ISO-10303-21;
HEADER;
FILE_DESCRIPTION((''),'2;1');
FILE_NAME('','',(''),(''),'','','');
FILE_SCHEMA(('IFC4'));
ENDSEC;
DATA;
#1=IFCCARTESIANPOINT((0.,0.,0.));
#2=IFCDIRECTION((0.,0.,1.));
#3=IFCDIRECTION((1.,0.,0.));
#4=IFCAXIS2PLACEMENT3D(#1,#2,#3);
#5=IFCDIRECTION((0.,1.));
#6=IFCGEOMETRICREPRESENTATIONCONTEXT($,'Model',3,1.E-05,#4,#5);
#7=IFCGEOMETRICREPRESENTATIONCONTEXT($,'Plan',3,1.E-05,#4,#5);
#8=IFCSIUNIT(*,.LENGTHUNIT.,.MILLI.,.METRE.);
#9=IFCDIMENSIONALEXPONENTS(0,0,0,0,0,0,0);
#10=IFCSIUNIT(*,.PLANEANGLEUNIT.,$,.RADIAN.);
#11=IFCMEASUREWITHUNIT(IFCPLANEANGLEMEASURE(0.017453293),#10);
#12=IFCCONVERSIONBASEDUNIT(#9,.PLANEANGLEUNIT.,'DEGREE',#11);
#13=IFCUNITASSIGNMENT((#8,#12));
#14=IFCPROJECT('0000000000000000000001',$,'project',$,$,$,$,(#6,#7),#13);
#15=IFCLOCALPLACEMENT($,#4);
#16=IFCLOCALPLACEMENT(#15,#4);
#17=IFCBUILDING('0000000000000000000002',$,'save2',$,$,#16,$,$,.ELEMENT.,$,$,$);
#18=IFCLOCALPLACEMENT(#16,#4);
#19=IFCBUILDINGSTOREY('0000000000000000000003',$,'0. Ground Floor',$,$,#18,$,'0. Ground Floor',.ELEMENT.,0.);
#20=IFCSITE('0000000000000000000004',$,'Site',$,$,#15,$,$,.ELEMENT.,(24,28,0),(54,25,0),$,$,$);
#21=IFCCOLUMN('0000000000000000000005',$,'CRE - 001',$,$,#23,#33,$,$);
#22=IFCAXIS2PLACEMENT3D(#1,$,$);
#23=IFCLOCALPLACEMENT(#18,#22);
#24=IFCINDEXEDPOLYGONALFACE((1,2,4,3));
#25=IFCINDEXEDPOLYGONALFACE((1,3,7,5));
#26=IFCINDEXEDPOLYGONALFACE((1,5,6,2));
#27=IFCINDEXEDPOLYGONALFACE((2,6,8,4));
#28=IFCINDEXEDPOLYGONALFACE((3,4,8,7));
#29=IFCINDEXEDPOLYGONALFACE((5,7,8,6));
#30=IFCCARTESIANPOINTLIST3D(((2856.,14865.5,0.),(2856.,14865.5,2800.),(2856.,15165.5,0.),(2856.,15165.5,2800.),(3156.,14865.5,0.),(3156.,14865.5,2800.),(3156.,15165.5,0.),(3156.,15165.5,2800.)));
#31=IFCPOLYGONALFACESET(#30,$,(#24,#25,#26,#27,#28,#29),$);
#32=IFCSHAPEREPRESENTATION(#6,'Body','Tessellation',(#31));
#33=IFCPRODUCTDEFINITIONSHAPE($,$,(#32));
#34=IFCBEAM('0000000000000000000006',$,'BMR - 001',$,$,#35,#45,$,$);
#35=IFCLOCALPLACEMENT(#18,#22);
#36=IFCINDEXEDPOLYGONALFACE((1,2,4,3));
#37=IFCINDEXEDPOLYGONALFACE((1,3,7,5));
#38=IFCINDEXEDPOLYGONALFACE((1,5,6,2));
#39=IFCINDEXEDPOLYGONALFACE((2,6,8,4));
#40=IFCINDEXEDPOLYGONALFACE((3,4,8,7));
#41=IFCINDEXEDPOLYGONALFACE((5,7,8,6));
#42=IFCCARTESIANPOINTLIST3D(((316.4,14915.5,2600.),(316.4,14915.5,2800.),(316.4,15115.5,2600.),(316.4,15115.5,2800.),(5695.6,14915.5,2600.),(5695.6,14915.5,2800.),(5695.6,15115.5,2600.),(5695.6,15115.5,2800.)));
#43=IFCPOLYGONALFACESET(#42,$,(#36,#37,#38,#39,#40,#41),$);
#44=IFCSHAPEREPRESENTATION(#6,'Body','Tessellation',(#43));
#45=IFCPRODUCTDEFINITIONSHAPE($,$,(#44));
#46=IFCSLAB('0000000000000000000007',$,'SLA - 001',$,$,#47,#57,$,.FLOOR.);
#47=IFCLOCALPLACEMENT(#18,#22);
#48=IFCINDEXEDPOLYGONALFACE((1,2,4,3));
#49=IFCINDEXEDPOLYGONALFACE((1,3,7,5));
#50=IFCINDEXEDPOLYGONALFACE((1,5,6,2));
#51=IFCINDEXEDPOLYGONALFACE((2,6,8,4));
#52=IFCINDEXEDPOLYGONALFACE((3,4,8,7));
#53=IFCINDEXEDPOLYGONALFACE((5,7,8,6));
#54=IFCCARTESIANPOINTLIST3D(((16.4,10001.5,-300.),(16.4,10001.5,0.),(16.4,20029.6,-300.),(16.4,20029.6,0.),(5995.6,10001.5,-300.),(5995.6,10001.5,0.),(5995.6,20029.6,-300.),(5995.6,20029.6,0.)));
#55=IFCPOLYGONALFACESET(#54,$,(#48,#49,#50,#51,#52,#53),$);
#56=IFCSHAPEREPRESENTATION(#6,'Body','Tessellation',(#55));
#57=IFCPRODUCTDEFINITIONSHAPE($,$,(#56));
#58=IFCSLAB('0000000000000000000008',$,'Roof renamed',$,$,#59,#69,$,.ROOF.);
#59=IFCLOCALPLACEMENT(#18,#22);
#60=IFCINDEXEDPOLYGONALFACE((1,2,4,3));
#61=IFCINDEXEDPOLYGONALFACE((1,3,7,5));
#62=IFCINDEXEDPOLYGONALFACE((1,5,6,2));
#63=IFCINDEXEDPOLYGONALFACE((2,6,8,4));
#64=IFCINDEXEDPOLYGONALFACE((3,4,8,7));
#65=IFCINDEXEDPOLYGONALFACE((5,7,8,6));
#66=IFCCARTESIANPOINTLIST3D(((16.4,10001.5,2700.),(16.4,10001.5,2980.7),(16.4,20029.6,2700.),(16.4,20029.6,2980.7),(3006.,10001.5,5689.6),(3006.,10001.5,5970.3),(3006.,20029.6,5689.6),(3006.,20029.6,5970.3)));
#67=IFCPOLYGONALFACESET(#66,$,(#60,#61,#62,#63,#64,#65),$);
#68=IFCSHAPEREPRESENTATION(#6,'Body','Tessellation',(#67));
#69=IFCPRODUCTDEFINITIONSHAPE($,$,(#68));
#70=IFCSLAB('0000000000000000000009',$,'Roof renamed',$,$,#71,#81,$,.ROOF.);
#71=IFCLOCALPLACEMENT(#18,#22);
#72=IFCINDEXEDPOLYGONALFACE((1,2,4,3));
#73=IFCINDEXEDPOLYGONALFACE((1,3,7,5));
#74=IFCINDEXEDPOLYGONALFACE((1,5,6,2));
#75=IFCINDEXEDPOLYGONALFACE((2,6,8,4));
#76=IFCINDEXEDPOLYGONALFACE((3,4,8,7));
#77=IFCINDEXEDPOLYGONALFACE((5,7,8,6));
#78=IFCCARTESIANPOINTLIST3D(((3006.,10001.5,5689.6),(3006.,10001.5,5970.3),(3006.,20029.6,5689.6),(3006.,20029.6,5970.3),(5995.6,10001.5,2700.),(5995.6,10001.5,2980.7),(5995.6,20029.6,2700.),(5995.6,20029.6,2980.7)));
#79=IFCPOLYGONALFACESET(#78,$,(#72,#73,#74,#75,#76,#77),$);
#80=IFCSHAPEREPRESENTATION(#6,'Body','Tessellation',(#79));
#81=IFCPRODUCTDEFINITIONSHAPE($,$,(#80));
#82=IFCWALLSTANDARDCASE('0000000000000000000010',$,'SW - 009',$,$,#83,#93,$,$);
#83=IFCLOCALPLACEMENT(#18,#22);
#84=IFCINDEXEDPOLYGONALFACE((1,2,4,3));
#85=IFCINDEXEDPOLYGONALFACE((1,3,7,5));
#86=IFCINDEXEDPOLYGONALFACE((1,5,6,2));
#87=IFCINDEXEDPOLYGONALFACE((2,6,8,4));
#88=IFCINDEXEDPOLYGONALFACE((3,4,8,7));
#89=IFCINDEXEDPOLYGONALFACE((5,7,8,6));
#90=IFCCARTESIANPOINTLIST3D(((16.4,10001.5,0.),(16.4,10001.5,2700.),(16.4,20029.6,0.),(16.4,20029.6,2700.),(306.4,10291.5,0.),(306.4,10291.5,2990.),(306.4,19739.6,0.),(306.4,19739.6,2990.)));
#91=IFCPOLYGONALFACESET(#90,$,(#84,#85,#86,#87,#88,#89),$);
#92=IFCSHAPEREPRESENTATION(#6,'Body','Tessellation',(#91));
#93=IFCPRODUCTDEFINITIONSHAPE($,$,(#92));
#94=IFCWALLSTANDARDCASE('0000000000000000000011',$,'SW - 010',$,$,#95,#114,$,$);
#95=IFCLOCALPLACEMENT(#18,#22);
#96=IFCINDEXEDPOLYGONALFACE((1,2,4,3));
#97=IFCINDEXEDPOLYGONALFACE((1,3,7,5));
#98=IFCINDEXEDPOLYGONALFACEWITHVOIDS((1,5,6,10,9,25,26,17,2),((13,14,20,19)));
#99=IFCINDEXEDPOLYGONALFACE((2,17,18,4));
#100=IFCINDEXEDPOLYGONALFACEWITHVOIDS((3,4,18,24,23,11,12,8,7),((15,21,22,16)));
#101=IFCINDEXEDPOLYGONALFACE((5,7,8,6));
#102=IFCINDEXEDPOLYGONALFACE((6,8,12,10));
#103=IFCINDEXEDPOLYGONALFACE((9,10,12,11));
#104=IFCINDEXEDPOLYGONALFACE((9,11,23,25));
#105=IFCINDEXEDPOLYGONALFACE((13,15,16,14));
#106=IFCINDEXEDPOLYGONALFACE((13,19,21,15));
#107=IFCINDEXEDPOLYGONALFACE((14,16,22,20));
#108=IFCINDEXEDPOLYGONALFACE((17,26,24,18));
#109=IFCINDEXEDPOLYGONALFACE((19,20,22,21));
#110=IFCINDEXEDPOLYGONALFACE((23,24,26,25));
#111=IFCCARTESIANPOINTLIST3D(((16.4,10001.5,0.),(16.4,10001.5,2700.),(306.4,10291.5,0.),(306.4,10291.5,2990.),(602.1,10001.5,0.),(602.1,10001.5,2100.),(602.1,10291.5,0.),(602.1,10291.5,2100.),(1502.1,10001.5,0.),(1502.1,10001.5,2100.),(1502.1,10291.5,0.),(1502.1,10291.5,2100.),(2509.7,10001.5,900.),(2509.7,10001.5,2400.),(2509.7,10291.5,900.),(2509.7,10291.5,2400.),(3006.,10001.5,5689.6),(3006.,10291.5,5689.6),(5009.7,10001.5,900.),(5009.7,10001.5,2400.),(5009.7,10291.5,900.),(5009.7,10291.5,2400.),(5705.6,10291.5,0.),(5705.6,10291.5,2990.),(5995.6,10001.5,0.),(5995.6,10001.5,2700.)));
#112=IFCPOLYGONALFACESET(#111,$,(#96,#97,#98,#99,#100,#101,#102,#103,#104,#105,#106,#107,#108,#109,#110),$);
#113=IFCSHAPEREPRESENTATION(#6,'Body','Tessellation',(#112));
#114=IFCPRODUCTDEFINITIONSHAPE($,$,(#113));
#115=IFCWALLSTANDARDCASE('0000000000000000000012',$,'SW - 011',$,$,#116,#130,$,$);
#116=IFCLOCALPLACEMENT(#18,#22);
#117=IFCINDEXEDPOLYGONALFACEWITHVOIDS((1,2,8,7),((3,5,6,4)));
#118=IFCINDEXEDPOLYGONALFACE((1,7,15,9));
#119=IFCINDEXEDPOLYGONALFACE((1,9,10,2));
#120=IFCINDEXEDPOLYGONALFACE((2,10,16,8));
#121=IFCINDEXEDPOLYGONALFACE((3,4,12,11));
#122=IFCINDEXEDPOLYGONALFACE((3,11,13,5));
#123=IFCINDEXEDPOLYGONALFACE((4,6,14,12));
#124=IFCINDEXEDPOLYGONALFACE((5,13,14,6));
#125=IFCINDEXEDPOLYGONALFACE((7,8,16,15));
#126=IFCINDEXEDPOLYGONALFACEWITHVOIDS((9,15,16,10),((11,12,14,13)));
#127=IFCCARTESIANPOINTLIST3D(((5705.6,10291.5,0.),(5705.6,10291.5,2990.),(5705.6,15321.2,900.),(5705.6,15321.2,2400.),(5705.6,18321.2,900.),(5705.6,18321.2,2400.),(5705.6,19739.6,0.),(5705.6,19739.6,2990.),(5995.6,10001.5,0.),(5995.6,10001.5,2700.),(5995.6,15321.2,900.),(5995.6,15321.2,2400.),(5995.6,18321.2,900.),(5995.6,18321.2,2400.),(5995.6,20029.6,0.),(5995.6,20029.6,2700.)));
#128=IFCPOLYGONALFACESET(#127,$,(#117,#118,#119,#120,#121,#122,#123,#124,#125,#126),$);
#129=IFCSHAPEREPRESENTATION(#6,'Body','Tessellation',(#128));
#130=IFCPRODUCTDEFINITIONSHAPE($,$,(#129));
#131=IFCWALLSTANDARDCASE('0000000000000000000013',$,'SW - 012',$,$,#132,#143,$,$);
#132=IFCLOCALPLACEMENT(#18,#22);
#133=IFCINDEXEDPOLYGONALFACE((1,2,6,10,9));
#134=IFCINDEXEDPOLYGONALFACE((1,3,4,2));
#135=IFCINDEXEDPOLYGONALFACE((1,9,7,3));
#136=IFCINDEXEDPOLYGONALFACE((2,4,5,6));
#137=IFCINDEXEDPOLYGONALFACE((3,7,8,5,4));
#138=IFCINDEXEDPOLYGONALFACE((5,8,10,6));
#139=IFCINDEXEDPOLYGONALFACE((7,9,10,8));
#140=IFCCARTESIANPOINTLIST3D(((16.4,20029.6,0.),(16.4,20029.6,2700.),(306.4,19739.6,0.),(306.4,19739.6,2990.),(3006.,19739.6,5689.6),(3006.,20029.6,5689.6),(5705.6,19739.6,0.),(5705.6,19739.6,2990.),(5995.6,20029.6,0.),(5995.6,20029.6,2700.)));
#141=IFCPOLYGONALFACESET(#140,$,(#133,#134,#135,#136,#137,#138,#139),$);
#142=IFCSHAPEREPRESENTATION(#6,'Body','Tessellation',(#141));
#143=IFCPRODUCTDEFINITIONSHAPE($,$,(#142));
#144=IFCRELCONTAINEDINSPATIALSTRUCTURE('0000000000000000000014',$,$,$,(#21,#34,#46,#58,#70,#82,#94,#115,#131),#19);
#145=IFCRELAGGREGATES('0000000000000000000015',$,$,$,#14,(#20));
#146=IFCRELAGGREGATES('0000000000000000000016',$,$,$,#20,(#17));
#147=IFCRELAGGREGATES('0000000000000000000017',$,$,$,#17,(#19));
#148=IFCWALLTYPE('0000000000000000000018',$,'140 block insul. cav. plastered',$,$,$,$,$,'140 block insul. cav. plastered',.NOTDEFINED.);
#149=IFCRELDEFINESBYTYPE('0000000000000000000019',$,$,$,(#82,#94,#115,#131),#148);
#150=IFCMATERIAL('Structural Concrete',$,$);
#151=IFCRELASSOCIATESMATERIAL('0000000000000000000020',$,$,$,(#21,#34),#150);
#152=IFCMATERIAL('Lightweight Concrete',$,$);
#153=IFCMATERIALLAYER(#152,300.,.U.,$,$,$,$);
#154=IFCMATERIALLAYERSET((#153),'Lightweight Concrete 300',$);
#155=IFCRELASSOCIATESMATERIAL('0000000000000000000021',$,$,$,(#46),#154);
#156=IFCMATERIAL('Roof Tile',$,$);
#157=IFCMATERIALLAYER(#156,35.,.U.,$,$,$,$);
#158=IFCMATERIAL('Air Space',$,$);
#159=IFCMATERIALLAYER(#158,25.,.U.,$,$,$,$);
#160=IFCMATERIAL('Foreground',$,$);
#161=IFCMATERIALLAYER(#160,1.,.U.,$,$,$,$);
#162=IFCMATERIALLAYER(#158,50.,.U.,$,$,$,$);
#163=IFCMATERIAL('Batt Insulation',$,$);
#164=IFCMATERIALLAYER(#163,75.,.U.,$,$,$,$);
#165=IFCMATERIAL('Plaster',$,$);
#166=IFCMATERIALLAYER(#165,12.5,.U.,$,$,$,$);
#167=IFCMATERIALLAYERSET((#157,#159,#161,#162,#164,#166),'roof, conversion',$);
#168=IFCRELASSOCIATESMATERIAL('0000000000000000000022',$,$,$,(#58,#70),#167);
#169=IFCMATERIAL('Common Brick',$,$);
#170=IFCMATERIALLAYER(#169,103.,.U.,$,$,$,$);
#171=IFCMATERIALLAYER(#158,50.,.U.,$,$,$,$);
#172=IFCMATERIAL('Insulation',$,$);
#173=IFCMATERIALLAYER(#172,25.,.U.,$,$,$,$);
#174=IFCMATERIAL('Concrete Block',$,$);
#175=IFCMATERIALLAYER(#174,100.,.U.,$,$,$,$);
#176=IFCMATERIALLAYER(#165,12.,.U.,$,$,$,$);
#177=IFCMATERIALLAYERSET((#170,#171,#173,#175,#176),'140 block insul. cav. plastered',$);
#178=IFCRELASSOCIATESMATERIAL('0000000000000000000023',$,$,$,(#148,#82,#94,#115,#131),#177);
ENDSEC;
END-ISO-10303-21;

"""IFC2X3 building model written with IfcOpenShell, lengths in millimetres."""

from ifc_helpers import new_model, entity, si_unit, converted_unit, direction, frame, frame_2d, origin_with_axes, origin_2d_with_axis, place, context, project, spatial, polyline, rectangle, outline, extrude, clip, halfspace, bounded_halfspace, material, layer, layer_set, layer_usage, type_object, element, save


model = new_model("IFC2X3")

# Units and contexts
model_context = context("Model", 3, precision=1e-05, world=origin_with_axes(), true_north=direction((0.0, 1.0)))
plan_context = context("Plan", 3, precision=1e-05, world=origin_with_axes(), true_north=direction((0.0, 1.0)))
ifc_project = project(units=[si_unit("LENGTHUNIT", "METRE", prefix="MILLI"), converted_unit("PLANEANGLEUNIT", "DEGREE", entity("IfcPlaneAngleMeasure", 0.017453293), si_unit("PLANEANGLEUNIT", "RADIAN"), dimensions=[0, 0, 0, 0, 0, 0, 0])], contexts=[model_context, plan_context])

# Site, building, storey
site_placement = place(None, origin_with_axes())
site = spatial("IfcSite", under=ifc_project, at=site_placement, Name="Site", CompositionType="ELEMENT", RefLatitude=(24, 28, 0), RefLongitude=(54, 25, 0))
building_placement = place(site_placement, origin_with_axes())
building = spatial("IfcBuilding", under=site, at=building_placement, Name="save2", CompositionType="ELEMENT")
storey_placement = place(building_placement, origin_with_axes())
storey = spatial("IfcBuildingStorey", under=building, at=storey_placement, Name="0. Ground Floor", LongName="0. Ground Floor", CompositionType="ELEMENT", Elevation=0.0)

# Column
ifc_material_1 = material(Name="Structural Concrete")
column_placement = place(storey_placement, frame((3006.0, 15015.5, 0.0), z_axis=(0.0, 0.0, 1.0), x_axis=(1.0, 0.0, 0.0)))
element("IfcColumn", 1, at=column_placement, inside=storey, material=ifc_material_1, Name="CRE - 001", context=model_context, shape_type="SweptSolid", body=[
    extrude(rectangle(XDim=300.0, YDim=300.0, at=origin_2d_with_axis()), origin_with_axes(), (0.0, 0.0, 1.0), 2800.0),
])

# Beam
beam_placement = place(storey_placement, frame((316.4, 15015.5, 2800.0), z_axis=(0.0, 0.0, 1.0), x_axis=(0.0, -1.0, 0.0)))
element("IfcBeam", 2, at=beam_placement, inside=storey, material=ifc_material_1, Name="BMR - 001", context=model_context, shape_type="SweptSolid", body=[
    extrude(rectangle(XDim=200.0, YDim=200.0, at=frame_2d((-100.0, 0.0), x_axis=(1.0, 0.0))), frame((0.0, 0.0, 0.0), z_axis=(0.0, 1.0, 0.0), x_axis=(0.0, 0.0, 1.0)), (0.0, 0.0, 1.0), 5379.1),
])

# Slabs
ifc_material_2 = material(Name="Lightweight Concrete")
ifc_layer_1 = layer(ifc_material_2, 300.0, ventilated="UNKNOWN")
ifc_layer_set_1 = layer_set([ifc_layer_1], Name="Lightweight Concrete 300")
ifc_layer_usage_1 = layer_usage(ifc_layer_set_1, "AXIS3", "NEGATIVE", 300.0)
slab_1_placement = place(storey_placement, frame((16.4, 20029.6, -300.0), z_axis=(0.0, 0.0, 1.0), x_axis=(1.0, 0.0, 0.0)))
element("IfcSlab", 3, at=slab_1_placement, inside=storey, material=ifc_layer_usage_1, Name="SLA - 001", PredefinedType="FLOOR", context=model_context, shape_type="SweptSolid", body=[
    extrude(outline(polyline([(0.0, 0.0), (5979.1, 0.0), (5979.1, -10028.0), (0.0, -10028.0), (0.0, 0.0)])), origin_with_axes(), (0.0, 0.0, 1.0), 300.0),
])
ifc_material_3 = material(Name="Roof Tile")
ifc_layer_2 = layer(ifc_material_3, 35.0, ventilated="UNKNOWN")
ifc_material_4 = material(Name="Air Space")
ifc_layer_3 = layer(ifc_material_4, 25.0, ventilated="UNKNOWN")
ifc_material_5 = material(Name="Foreground")
ifc_layer_4 = layer(ifc_material_5, 1.0, ventilated="UNKNOWN")
ifc_layer_5 = layer(ifc_material_4, 50.0, ventilated="UNKNOWN")
ifc_material_6 = material(Name="Batt Insulation")
ifc_layer_6 = layer(ifc_material_6, 75.0, ventilated="UNKNOWN")
ifc_material_7 = material(Name="Plaster")
ifc_layer_7 = layer(ifc_material_7, 12.5, ventilated="UNKNOWN")
ifc_layer_set_2 = layer_set([ifc_layer_2, ifc_layer_3, ifc_layer_4, ifc_layer_5, ifc_layer_6, ifc_layer_7], Name="roof, conversion")
ifc_layer_usage_2 = layer_usage(ifc_layer_set_2, "AXIS3", "NEGATIVE", 198.5)
slab_2_placement = place(storey_placement, frame((16.4, 20029.6, 2700.0), z_axis=(-0.707107, 0.0, 0.707107), x_axis=(0.0, -1.0, 0.0)))
element("IfcSlab", 4, at=slab_2_placement, inside=storey, material=ifc_layer_usage_2, Name="Roof renamed", PredefinedType="ROOF", context=model_context, shape_type="SweptSolid", body=[
    extrude(outline(polyline([(0.0, 0.0), (0.0, 4227.9), (10028.0, 4227.9), (10028.0, 0.0), (0.0, 0.0)])), origin_with_axes(), (0.0, 0.707107, 0.707107), 280.7),
])
ifc_layer_usage_3 = layer_usage(ifc_layer_set_2, "AXIS3", "NEGATIVE", 198.5)
slab_3_placement = place(storey_placement, frame((5995.6, 10001.5, 2700.0), z_axis=(0.707107, 0.0, 0.707107), x_axis=(0.0, 1.0, 0.0)))
element("IfcSlab", 5, at=slab_3_placement, inside=storey, material=ifc_layer_usage_3, Name="Roof renamed", PredefinedType="ROOF", context=model_context, shape_type="SweptSolid", body=[
    extrude(outline(polyline([(0.0, 0.0), (10028.0, 0.0), (10028.0, 4227.9), (0.0, 4227.9), (0.0, 0.0)])), origin_with_axes(), (0.0, 0.707107, 0.707107), 280.7),
])

# Wall
ifc_material_8 = material(Name="Common Brick")
ifc_layer_8 = layer(ifc_material_8, 103.0, ventilated="UNKNOWN")
ifc_layer_9 = layer(ifc_material_4, 50.0, ventilated="UNKNOWN")
ifc_material_9 = material(Name="Insulation")
ifc_layer_10 = layer(ifc_material_9, 25.0, ventilated="UNKNOWN")
ifc_material_10 = material(Name="Concrete Block")
ifc_layer_11 = layer(ifc_material_10, 100.0, ventilated="UNKNOWN")
ifc_layer_12 = layer(ifc_material_7, 12.0, ventilated="UNKNOWN")
ifc_layer_set_3 = layer_set([ifc_layer_8, ifc_layer_9, ifc_layer_10, ifc_layer_11, ifc_layer_12], Name="140 block insul. cav. plastered")
ifc_layer_usage_4 = layer_usage(ifc_layer_set_3, "AXIS2", "POSITIVE", 0.0)
wall_type_1 = type_object("IfcWallType", Name="140 block insul. cav. plastered", ElementType="140 block insul. cav. plastered", PredefinedType="NOTDEFINED", material=ifc_layer_set_3)
wall_1_placement = place(storey_placement, frame((16.4, 20029.6, 0.0), z_axis=(0.0, 0.0, 1.0), x_axis=(0.0, -1.0, 0.0)))
element("IfcWallStandardCase", 6, at=wall_1_placement, inside=storey, type_object=wall_type_1, material=ifc_layer_usage_4, Name="SW - 009", context=model_context, shape_type="Clipping", body=[
    clip(extrude(outline(polyline([(0.0, 0.0), (10028.0, 0.0), (9738.0, 290.0), (290.0, 290.0), (0.0, 0.0)])), origin_with_axes(), (0.0, 0.0, 1.0), 6000.0), halfspace(frame((0.0, -1350.0, 1350.0), z_axis=(0.0, 0.707107, -0.707107), x_axis=(0.0, 0.707107, 0.707107)), True)),
])

# Wall, openings
ifc_layer_usage_5 = layer_usage(ifc_layer_set_3, "AXIS2", "POSITIVE", 0.0)
wall_2_placement = place(storey_placement, frame((16.4, 10001.5, 0.0), z_axis=(0.0, 0.0, 1.0), x_axis=(1.0, 0.0, 0.0)))
wall_2 = element("IfcWallStandardCase", 7, at=wall_2_placement, inside=storey, type_object=wall_type_1, material=ifc_layer_usage_5, Name="SW - 010", context=model_context, shape_type="Clipping", body=[
    clip(clip(extrude(outline(polyline([(0.0, 0.0), (5979.1, 0.0), (5689.1, 290.0), (290.0, 290.0), (0.0, 0.0)])), origin_with_axes(), (0.0, 0.0, 1.0), 6000.0), bounded_halfspace(frame((-1350.0, 0.0, 1350.0), z_axis=(0.707107, 0.0, -0.707107), x_axis=(0.0, 1.0, 0.0)), True, origin_with_axes(), polyline([(2989.6, -145.0), (2989.6, 435.0), (-10.0, 435.0), (-10.0, -145.0), (2989.6, -145.0)]))), bounded_halfspace(frame((4339.6, 0.0, 4339.6), z_axis=(-0.707107, 0.0, -0.707107), x_axis=(0.0, 1.0, 0.0)), True, origin_with_axes(), polyline([(2989.6, -145.0), (2989.6, 435.0), (5989.1, 435.0), (5989.1, -145.0), (2989.6, -145.0)]))),
])
opening_1_placement = place(wall_2_placement, frame((1035.6, 0.0, 0.0), z_axis=(0.0, 0.0, 1.0), x_axis=(1.0, 0.0, 0.0)))
element("IfcOpeningElement", 8, at=opening_1_placement, cuts=wall_2, ObjectType="Opening", context=model_context, shape_type="SweptSolid", body=[
    extrude(rectangle(XDim=900.0, YDim=2100.0, at=frame_2d((0.0, 1050.0), x_axis=(-1.0, 0.0))), frame((0.0, 0.0, 0.0), z_axis=(0.0, 1.0, 0.0), x_axis=(-1.0, 0.0, 0.0)), (0.0, 0.0, 1.0), 290.0),
])
opening_2_placement = place(wall_2_placement, frame((3743.3, 0.0, 900.0), z_axis=(0.0, 0.0, 1.0), x_axis=(1.0, 0.0, 0.0)))
element("IfcOpeningElement", 9, at=opening_2_placement, cuts=wall_2, ObjectType="Opening", context=model_context, shape_type="SweptSolid", body=[
    extrude(rectangle(XDim=2500.0, YDim=1500.0, at=frame_2d((0.0, 750.0), x_axis=(-1.0, 0.0))), frame((0.0, 0.0, 0.0), z_axis=(0.0, 1.0, 0.0), x_axis=(-1.0, 0.0, 0.0)), (0.0, 0.0, 1.0), 290.0),
])

# Wall, opening
ifc_layer_usage_6 = layer_usage(ifc_layer_set_3, "AXIS2", "POSITIVE", 0.0)
wall_3_placement = place(storey_placement, frame((5995.6, 10001.5, 0.0), z_axis=(0.0, 0.0, 1.0), x_axis=(0.0, 1.0, 0.0)))
wall_3 = element("IfcWallStandardCase", 10, at=wall_3_placement, inside=storey, type_object=wall_type_1, material=ifc_layer_usage_6, Name="SW - 011", context=model_context, shape_type="Clipping", body=[
    clip(extrude(outline(polyline([(0.0, 0.0), (10028.0, 0.0), (9738.0, 290.0), (290.0, 290.0), (0.0, 0.0)])), origin_with_axes(), (0.0, 0.0, 1.0), 6000.0), halfspace(frame((0.0, -1350.0, 1350.0), z_axis=(0.0, 0.707107, -0.707107), x_axis=(0.0, 0.707107, 0.707107)), True)),
])
opening_3_placement = place(wall_3_placement, frame((6819.7, 0.0, 900.0), z_axis=(0.0, 0.0, 1.0), x_axis=(1.0, 0.0, 0.0)))
element("IfcOpeningElement", 11, at=opening_3_placement, cuts=wall_3, ObjectType="Opening", context=model_context, shape_type="SweptSolid", body=[
    extrude(rectangle(XDim=3000.0, YDim=1500.0, at=frame_2d((0.0, 750.0), x_axis=(1.0, 0.0))), frame((0.0, 0.0, 0.0), z_axis=(0.0, 1.0, 0.0), x_axis=(-1.0, 0.0, 0.0)), (0.0, 0.0, 1.0), 290.0),
])

# Wall
ifc_layer_usage_7 = layer_usage(ifc_layer_set_3, "AXIS2", "POSITIVE", 0.0)
wall_4_placement = place(storey_placement, frame((5995.6, 20029.6, 0.0), z_axis=(0.0, 0.0, 1.0), x_axis=(-1.0, 0.0, 0.0)))
element("IfcWallStandardCase", 12, at=wall_4_placement, inside=storey, type_object=wall_type_1, material=ifc_layer_usage_7, Name="SW - 012", context=model_context, shape_type="Clipping", body=[
    clip(clip(extrude(outline(polyline([(0.0, 0.0), (5979.1, 0.0), (5689.1, 290.0), (290.0, 290.0), (0.0, 0.0)])), origin_with_axes(), (0.0, 0.0, 1.0), 6000.0), bounded_halfspace(frame((4339.6, 0.0, 4339.6), z_axis=(-0.707107, 0.0, -0.707107), x_axis=(0.0, 1.0, 0.0)), True, origin_with_axes(), polyline([(2989.6, -145.0), (2989.6, 435.0), (5989.1, 435.0), (5989.1, -145.0), (2989.6, -145.0)]))), bounded_halfspace(frame((-1350.0, 0.0, 1350.0), z_axis=(0.707107, 0.0, -0.707107), x_axis=(0.0, 1.0, 0.0)), True, origin_with_axes(), polyline([(2989.6, -145.0), (2989.6, 435.0), (-10.0, 435.0), (-10.0, -145.0), (2989.6, -145.0)]))),
])

save(model, "model.ifc")
